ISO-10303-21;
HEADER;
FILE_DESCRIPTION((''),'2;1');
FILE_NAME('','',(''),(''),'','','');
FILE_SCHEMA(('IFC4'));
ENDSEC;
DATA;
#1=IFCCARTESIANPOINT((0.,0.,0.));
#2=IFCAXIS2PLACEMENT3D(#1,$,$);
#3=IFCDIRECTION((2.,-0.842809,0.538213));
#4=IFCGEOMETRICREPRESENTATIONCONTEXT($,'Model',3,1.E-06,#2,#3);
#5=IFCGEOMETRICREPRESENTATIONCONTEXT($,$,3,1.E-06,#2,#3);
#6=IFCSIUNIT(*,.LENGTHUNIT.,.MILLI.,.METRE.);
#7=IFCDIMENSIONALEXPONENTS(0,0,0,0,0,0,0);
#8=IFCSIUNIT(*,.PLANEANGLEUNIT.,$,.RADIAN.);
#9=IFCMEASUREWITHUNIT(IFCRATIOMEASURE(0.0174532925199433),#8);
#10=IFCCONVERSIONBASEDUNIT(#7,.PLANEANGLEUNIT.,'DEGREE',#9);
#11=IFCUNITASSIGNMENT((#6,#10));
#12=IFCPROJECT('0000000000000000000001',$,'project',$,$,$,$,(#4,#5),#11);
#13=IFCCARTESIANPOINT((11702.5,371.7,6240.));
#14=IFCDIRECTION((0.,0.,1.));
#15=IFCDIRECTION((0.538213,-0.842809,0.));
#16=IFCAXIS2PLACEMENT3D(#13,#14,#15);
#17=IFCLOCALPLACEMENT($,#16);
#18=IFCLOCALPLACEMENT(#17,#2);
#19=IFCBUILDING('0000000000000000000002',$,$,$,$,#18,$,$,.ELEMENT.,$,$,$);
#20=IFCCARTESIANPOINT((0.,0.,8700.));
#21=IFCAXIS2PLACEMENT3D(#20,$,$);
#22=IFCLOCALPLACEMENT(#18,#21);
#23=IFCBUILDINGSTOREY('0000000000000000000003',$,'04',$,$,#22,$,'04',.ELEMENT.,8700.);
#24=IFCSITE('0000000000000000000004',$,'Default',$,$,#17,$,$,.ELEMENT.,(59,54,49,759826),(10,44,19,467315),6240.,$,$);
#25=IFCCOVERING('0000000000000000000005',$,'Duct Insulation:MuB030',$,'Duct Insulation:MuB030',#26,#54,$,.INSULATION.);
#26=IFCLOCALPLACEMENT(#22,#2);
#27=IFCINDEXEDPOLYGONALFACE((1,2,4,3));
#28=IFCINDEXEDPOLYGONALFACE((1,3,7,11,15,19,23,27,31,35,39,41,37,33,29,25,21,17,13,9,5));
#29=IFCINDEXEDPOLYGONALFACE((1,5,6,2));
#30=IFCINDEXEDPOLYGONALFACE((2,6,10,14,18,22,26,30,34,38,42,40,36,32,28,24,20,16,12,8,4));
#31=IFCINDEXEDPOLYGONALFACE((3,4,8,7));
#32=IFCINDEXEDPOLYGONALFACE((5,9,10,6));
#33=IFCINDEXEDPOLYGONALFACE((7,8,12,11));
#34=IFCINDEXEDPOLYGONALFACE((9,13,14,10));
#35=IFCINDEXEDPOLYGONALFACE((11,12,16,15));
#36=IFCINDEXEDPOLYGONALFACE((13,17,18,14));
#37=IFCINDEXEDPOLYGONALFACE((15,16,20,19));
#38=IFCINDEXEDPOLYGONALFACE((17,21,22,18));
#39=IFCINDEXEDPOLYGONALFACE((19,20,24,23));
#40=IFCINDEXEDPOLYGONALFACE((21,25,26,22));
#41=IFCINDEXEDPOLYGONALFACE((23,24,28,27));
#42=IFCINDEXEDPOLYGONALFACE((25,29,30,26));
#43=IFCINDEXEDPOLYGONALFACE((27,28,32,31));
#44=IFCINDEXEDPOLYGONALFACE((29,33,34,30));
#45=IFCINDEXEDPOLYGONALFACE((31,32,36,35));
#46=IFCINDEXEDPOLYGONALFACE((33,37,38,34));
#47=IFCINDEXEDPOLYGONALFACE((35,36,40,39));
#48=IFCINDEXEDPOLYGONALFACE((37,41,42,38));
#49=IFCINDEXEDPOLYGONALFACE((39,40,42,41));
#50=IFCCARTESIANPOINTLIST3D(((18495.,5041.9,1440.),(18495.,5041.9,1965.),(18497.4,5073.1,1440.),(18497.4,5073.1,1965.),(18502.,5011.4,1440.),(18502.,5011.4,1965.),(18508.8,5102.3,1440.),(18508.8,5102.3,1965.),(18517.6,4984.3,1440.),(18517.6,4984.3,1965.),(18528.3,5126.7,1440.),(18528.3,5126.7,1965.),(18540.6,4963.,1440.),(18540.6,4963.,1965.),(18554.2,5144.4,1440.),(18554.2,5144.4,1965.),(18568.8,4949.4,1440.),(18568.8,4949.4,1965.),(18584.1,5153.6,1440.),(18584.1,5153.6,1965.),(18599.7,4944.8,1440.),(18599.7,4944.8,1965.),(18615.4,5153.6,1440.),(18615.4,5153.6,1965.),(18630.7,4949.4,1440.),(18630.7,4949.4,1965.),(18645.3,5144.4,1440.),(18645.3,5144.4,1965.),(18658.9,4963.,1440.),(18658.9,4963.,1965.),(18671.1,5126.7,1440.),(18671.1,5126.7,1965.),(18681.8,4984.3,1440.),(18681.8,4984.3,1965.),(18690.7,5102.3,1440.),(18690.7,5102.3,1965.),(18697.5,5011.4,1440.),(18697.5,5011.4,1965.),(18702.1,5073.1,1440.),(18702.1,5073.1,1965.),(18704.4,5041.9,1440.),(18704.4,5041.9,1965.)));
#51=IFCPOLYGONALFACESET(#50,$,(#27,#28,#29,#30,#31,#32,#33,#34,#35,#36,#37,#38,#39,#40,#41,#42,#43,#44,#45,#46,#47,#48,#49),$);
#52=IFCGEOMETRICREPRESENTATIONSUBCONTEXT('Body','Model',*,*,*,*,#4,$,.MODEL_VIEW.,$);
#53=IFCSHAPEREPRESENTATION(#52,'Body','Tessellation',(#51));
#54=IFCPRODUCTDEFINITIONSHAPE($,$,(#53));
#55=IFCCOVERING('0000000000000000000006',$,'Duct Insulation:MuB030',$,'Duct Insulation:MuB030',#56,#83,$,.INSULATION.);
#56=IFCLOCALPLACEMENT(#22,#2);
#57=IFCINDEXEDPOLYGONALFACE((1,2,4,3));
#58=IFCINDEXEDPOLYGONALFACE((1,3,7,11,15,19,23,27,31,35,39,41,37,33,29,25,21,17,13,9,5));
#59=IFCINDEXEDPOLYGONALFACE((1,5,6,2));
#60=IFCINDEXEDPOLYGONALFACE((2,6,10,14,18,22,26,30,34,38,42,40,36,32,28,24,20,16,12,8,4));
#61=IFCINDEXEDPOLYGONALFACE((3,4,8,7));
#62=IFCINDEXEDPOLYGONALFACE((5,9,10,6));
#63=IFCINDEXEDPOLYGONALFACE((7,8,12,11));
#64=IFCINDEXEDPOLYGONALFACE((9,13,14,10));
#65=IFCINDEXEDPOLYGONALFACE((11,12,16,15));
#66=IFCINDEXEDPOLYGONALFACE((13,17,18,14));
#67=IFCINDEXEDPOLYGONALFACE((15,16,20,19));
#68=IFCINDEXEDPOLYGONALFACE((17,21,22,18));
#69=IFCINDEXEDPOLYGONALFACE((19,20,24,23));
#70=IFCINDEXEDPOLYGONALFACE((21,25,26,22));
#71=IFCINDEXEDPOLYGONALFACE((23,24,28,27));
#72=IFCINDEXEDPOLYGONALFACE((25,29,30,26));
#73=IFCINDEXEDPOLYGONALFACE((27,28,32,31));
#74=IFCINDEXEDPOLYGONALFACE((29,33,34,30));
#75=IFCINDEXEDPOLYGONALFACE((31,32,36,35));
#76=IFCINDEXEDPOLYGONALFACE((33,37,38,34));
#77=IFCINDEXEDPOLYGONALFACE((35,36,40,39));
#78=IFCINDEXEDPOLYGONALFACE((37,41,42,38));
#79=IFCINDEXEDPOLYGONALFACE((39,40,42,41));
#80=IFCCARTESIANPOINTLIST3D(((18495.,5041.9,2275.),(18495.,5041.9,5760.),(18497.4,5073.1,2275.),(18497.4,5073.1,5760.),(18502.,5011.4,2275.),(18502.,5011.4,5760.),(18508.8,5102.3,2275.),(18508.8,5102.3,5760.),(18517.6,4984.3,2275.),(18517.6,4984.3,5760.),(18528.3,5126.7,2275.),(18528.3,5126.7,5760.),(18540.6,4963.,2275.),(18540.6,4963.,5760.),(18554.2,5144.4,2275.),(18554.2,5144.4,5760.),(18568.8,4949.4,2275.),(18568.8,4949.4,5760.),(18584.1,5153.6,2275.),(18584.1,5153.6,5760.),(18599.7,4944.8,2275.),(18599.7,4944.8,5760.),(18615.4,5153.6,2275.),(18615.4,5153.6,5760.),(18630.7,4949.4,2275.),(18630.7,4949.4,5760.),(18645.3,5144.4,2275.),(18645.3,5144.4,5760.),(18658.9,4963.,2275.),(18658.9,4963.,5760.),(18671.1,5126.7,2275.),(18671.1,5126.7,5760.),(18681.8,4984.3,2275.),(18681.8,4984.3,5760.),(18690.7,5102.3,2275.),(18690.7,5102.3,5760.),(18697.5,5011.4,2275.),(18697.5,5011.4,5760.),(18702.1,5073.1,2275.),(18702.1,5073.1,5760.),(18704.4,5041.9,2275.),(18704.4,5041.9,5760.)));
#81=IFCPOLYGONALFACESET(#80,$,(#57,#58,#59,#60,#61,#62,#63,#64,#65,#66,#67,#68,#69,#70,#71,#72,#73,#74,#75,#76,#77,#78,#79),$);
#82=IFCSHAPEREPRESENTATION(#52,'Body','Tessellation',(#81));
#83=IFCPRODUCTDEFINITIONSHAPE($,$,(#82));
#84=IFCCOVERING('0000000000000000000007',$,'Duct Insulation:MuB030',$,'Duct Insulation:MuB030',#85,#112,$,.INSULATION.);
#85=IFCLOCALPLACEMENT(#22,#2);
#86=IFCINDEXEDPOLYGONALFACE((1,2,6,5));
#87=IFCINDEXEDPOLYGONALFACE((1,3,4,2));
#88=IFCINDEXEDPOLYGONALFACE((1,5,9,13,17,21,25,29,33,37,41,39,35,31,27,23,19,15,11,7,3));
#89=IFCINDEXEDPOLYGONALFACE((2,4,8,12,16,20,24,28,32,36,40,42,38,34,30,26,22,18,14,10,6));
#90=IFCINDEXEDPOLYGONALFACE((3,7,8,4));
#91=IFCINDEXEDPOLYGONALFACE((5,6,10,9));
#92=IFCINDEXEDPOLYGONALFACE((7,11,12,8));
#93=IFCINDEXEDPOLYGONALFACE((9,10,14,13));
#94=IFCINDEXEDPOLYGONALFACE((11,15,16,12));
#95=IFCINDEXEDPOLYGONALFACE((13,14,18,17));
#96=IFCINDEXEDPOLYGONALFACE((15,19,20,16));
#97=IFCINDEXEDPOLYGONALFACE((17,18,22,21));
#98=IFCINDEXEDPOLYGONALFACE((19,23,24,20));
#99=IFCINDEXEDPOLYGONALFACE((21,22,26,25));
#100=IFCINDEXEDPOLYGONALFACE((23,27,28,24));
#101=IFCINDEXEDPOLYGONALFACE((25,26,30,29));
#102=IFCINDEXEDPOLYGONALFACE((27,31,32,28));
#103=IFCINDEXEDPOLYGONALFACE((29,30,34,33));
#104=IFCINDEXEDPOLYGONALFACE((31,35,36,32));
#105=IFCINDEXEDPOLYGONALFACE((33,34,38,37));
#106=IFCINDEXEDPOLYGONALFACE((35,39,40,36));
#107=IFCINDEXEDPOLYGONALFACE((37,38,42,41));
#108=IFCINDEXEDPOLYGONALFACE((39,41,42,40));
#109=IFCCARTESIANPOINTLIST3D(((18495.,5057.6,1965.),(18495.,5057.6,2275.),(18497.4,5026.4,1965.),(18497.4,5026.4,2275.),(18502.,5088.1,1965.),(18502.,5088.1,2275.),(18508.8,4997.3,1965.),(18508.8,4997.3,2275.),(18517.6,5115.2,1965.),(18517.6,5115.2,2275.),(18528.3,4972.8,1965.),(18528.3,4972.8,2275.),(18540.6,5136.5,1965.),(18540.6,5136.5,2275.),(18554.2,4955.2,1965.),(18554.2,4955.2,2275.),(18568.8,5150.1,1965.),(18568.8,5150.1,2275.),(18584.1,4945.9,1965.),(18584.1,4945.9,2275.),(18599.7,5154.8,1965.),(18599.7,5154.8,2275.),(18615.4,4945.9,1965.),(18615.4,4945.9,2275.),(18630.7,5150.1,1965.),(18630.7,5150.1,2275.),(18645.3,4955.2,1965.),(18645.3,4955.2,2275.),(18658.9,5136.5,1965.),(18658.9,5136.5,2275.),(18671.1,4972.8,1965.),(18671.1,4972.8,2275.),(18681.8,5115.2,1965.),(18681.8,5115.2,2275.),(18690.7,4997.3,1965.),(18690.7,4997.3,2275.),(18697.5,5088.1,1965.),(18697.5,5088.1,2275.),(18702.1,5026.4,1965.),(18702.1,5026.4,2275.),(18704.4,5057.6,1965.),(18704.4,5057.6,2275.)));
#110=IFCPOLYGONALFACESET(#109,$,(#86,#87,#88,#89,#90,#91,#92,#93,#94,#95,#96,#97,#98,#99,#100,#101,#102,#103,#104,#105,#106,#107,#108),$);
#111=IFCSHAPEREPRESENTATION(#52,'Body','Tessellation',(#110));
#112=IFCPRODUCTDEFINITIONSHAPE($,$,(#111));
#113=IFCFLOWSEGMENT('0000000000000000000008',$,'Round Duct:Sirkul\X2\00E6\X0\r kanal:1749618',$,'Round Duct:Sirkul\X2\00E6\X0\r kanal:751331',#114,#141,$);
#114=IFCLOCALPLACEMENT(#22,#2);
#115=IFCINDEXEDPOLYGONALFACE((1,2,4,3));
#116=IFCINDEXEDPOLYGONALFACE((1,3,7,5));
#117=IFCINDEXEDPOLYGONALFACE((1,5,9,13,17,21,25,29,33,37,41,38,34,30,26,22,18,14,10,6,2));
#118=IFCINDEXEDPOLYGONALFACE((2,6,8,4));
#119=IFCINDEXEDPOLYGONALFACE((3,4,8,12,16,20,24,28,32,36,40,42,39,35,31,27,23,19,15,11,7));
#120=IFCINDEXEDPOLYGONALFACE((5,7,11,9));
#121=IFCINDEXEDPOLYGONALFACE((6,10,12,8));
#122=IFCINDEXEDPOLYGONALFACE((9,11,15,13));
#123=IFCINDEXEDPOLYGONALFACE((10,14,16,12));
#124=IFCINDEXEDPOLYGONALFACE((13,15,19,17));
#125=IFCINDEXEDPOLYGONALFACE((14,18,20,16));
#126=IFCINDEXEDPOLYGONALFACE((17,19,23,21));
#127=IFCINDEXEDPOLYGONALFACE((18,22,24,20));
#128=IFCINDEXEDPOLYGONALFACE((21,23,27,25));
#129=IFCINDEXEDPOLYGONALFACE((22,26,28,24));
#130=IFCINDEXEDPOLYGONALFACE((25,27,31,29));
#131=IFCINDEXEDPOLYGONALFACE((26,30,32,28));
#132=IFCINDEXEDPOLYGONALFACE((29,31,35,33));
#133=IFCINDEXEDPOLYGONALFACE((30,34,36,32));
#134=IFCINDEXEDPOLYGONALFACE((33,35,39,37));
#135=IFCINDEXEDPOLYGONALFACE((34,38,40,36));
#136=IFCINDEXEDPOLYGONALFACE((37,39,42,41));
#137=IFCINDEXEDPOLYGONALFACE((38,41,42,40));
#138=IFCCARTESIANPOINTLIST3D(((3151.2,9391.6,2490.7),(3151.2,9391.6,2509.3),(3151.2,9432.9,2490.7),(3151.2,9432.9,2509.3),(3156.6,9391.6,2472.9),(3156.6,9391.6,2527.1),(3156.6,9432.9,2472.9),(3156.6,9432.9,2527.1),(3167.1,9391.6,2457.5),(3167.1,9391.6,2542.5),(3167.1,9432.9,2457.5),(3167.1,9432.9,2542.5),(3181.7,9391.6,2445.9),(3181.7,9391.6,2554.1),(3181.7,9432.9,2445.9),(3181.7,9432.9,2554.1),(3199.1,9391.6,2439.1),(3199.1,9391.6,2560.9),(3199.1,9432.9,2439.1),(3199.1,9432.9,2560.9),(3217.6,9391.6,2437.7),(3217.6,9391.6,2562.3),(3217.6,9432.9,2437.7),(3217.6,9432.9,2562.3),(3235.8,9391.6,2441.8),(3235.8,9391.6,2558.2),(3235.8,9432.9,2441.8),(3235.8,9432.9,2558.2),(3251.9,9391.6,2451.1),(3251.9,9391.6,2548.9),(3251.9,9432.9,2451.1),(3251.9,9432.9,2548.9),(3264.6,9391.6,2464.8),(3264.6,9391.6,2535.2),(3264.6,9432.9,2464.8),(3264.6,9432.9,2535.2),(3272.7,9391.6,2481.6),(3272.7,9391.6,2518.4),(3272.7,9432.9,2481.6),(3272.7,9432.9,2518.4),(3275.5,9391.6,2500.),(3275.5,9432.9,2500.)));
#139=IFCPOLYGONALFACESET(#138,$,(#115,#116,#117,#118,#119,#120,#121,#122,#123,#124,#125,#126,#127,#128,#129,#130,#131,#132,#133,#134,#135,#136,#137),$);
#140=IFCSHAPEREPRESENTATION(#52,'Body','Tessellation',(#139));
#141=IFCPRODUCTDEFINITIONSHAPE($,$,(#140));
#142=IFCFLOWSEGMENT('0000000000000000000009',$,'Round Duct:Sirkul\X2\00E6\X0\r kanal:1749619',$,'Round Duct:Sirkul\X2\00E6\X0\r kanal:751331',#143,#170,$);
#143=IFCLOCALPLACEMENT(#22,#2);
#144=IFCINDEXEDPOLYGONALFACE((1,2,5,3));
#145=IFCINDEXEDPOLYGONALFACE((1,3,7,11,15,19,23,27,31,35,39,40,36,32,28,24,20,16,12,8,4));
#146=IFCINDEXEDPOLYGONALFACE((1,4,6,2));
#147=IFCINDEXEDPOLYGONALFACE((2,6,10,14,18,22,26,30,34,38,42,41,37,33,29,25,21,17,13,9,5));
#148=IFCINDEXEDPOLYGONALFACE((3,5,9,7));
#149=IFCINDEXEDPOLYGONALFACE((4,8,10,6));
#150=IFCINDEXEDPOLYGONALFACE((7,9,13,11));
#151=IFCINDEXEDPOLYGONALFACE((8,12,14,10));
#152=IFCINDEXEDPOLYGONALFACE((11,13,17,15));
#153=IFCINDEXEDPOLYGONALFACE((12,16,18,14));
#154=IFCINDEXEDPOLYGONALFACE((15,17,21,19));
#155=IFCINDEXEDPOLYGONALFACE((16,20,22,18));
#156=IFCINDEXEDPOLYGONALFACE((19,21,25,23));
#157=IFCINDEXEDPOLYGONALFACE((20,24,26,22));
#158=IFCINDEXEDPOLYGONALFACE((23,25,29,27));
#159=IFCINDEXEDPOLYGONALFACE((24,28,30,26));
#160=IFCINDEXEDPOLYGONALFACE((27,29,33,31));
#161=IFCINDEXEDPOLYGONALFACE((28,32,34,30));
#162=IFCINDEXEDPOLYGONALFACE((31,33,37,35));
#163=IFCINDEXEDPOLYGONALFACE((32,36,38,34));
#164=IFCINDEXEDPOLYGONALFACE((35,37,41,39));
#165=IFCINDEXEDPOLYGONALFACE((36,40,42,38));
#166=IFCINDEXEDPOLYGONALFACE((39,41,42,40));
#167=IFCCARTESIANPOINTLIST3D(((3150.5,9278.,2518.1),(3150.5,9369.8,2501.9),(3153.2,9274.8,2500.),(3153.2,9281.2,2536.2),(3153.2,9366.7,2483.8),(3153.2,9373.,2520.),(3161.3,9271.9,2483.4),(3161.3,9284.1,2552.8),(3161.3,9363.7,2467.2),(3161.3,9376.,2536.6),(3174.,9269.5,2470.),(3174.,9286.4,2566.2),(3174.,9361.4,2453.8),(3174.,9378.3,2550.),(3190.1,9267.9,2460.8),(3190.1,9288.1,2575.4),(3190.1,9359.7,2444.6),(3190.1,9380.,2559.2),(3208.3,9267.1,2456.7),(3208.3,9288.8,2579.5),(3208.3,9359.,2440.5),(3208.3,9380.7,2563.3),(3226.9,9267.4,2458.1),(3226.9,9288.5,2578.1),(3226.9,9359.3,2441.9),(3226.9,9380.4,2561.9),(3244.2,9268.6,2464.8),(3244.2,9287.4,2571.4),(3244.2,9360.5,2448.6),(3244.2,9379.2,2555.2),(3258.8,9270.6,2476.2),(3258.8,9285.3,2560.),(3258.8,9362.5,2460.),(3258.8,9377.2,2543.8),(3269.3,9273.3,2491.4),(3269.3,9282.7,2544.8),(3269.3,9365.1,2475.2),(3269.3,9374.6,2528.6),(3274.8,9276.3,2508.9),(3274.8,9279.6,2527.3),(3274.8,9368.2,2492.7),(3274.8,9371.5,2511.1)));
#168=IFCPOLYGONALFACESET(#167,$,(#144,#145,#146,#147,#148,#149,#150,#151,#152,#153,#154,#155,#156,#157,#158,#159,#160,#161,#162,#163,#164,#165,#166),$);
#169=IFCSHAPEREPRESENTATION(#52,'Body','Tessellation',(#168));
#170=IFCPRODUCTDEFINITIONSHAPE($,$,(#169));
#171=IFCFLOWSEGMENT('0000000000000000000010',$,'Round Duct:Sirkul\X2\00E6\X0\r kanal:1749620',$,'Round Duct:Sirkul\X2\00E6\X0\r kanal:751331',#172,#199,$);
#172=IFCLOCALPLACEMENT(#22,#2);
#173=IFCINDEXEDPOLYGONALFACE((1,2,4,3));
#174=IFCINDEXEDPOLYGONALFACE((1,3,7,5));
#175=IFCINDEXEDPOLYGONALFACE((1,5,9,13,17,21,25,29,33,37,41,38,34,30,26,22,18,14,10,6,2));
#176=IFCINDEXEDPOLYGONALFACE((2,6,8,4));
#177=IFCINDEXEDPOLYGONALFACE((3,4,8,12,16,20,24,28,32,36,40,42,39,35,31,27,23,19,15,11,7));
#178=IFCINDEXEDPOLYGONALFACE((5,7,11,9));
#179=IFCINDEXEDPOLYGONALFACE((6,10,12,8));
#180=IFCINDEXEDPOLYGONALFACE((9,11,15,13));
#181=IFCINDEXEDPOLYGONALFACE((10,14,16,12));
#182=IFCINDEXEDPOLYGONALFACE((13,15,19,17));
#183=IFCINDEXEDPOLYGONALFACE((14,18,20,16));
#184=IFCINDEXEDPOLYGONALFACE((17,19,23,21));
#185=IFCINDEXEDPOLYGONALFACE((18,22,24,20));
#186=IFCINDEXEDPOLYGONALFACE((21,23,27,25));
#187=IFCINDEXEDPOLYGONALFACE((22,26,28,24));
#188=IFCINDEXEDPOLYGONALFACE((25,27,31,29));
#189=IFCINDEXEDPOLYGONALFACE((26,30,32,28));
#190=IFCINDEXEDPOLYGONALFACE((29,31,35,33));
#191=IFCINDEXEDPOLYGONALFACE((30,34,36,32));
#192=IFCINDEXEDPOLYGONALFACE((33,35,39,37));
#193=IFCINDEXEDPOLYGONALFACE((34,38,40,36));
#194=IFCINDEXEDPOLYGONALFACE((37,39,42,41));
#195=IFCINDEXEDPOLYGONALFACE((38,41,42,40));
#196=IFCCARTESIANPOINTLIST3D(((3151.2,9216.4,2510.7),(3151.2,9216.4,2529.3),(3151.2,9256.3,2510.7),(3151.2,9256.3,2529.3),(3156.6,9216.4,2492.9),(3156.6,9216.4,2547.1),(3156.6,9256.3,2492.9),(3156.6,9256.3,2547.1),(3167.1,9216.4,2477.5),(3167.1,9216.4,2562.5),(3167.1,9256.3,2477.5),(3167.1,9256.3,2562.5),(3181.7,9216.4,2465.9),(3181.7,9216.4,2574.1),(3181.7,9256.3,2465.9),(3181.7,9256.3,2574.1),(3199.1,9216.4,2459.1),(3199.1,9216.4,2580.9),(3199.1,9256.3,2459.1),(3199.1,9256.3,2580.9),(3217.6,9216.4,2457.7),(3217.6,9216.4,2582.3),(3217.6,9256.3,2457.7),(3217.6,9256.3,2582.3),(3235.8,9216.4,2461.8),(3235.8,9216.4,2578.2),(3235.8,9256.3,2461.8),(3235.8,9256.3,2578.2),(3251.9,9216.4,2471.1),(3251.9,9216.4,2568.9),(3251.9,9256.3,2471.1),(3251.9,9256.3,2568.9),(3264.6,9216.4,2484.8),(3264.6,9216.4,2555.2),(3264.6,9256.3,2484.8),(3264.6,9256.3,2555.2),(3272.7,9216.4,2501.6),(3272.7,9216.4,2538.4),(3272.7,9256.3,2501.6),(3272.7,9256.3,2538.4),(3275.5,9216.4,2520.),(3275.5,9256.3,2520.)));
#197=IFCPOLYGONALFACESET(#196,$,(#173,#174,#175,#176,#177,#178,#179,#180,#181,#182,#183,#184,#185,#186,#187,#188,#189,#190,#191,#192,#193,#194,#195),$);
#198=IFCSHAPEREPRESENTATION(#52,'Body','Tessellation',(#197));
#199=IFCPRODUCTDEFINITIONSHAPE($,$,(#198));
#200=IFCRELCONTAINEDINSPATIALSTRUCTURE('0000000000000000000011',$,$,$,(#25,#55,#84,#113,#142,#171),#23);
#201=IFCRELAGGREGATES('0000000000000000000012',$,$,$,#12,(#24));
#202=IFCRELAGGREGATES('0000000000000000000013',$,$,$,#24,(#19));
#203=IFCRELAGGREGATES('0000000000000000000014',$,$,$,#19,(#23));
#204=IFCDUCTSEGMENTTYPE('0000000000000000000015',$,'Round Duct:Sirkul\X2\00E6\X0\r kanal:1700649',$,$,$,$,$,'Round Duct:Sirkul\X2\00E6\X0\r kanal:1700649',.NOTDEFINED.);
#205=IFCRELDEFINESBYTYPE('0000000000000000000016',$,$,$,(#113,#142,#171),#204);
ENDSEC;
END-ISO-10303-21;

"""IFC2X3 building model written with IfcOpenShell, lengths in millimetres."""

from ifc_helpers import new_model, entity, si_unit, converted_unit, direction, frame, frame_2d, origin, origin_2d_with_axis, place, context, subcontext, project, spatial, circle, extrude, type_object, element, save


model = new_model("IFC2X3")

# Units and contexts
model_context = context("Model", 3, precision=1e-06, world=origin(), true_north=direction((2.0, -0.842809, 0.538213)))
context_of_model = context(None, 3, precision=1e-06, world=origin(), true_north=direction((2.0, -0.842809, 0.538213)))
body_context = subcontext(model_context, "Body", "Model", "MODEL_VIEW")
ifc_project = project(units=[si_unit("LENGTHUNIT", "METRE", prefix="MILLI"), converted_unit("PLANEANGLEUNIT", "DEGREE", entity("IfcRatioMeasure", 0.0174532925199433), si_unit("PLANEANGLEUNIT", "RADIAN"), dimensions=[0, 0, 0, 0, 0, 0, 0])], contexts=[model_context, context_of_model])

# Site, building, storey
site_placement = place(None, frame((11702.5, 371.7, 6240.0), z_axis=(0.0, 0.0, 1.0), x_axis=(0.538213, -0.842809, 0.0)))
site = spatial("IfcSite", under=ifc_project, at=site_placement, Name="Default", CompositionType="ELEMENT", RefLatitude=(59, 54, 49, 759826), RefLongitude=(10, 44, 19, 467315), RefElevation=6240.0)
building_placement = place(site_placement, origin())
building = spatial("IfcBuilding", under=site, at=building_placement, CompositionType="ELEMENT")
storey_placement = place(building_placement, frame((0.0, 0.0, 8700.0)))
storey = spatial("IfcBuildingStorey", under=building, at=storey_placement, Name="04", LongName="04", CompositionType="ELEMENT", Elevation=8700.0)

# Coverings
covering_1_placement = place(storey_placement, origin())
element("IfcCovering", 1, at=covering_1_placement, inside=storey, Name="Duct Insulation:MuB030", ObjectType="Duct Insulation:MuB030", PredefinedType="INSULATION", context=body_context, shape_type="SweptSolid", body=[
    extrude(circle(Radius=105.0, at=frame_2d((0.0, 0.0), x_axis=(1.0, 0.0))), frame((18599.7, 5049.8, 1440.0), z_axis=(0.0, 0.0, 1.0), x_axis=(0.0, -1.0, 0.0)), (0.0, 0.0, 1.0), 525.0),
])
covering_2_placement = place(storey_placement, origin())
element("IfcCovering", 2, at=covering_2_placement, inside=storey, Name="Duct Insulation:MuB030", ObjectType="Duct Insulation:MuB030", PredefinedType="INSULATION", context=body_context, shape_type="SweptSolid", body=[
    extrude(circle(Radius=105.0, at=frame_2d((0.0, 0.0), x_axis=(1.0, 0.0))), frame((18599.7, 5049.8, 2275.0), z_axis=(0.0, 0.0, 1.0), x_axis=(0.0, -1.0, 0.0)), (0.0, 0.0, 1.0), 3485.0),
])
covering_3_placement = place(storey_placement, origin())
element("IfcCovering", 3, at=covering_3_placement, inside=storey, Name="Duct Insulation:MuB030", ObjectType="Duct Insulation:MuB030", PredefinedType="INSULATION", context=body_context, shape_type="SweptSolid", body=[
    extrude(circle(Radius=105.0, at=frame_2d((0.0, 0.0), x_axis=(1.0, 0.0))), frame((18599.7, 5049.8, 1965.0), z_axis=(0.0, 0.0, 1.0), x_axis=(0.0, 1.0, 0.0)), (0.0, 0.0, 1.0), 310.0),
])

# Flow segments
duct_segment_type = type_object("IfcDuctSegmentType", Name="Round Duct:Sirkulær kanal:1700649", ElementType="Round Duct:Sirkulær kanal:1700649", PredefinedType="NOTDEFINED")
flow_segment_1_placement = place(storey_placement, origin())
element("IfcFlowSegment", 4, at=flow_segment_1_placement, inside=storey, type_object=duct_segment_type, Name="Round Duct:Sirkulær kanal:1749618", ObjectType="Round Duct:Sirkulær kanal:751331", context=body_context, shape_type="SweptSolid", body=[
    extrude(circle(Radius=62.5, at=frame_2d((0.0, 0.0), x_axis=(1.0, 0.0))), frame((3213.0, 9391.6, 2500.0), z_axis=(0.0, 1.0, 0.0), x_axis=(1.0, 0.0, 0.0)), (0.0, 0.0, 1.0), 41.3),
])
flow_segment_2_placement = place(storey_placement, origin())
element("IfcFlowSegment", 5, at=flow_segment_2_placement, inside=storey, type_object=duct_segment_type, Name="Round Duct:Sirkulær kanal:1749619", ObjectType="Round Duct:Sirkulær kanal:751331", context=body_context, shape_type="SweptSolid", body=[
    extrude(circle(Radius=62.5, at=frame_2d((0.0, 0.0), x_axis=(1.0, 0.0))), frame((3213.0, 9278.0, 2518.1), z_axis=(0.0, 0.984808, -0.173648), x_axis=(-1.0, 0.0, 0.0)), (0.0, 0.0, 1.0), 93.3),
])
flow_segment_3_placement = place(storey_placement, origin())
element("IfcFlowSegment", 6, at=flow_segment_3_placement, inside=storey, type_object=duct_segment_type, Name="Round Duct:Sirkulær kanal:1749620", ObjectType="Round Duct:Sirkulær kanal:751331", context=body_context, shape_type="SweptSolid", body=[
    extrude(circle(Radius=62.5, at=origin_2d_with_axis()), frame((3213.0, 9216.4, 2520.0), z_axis=(0.0, 1.0, 0.0), x_axis=(1.0, 0.0, 0.0)), (0.0, 0.0, 1.0), 39.9),
])

save(model, "model.ifc")
